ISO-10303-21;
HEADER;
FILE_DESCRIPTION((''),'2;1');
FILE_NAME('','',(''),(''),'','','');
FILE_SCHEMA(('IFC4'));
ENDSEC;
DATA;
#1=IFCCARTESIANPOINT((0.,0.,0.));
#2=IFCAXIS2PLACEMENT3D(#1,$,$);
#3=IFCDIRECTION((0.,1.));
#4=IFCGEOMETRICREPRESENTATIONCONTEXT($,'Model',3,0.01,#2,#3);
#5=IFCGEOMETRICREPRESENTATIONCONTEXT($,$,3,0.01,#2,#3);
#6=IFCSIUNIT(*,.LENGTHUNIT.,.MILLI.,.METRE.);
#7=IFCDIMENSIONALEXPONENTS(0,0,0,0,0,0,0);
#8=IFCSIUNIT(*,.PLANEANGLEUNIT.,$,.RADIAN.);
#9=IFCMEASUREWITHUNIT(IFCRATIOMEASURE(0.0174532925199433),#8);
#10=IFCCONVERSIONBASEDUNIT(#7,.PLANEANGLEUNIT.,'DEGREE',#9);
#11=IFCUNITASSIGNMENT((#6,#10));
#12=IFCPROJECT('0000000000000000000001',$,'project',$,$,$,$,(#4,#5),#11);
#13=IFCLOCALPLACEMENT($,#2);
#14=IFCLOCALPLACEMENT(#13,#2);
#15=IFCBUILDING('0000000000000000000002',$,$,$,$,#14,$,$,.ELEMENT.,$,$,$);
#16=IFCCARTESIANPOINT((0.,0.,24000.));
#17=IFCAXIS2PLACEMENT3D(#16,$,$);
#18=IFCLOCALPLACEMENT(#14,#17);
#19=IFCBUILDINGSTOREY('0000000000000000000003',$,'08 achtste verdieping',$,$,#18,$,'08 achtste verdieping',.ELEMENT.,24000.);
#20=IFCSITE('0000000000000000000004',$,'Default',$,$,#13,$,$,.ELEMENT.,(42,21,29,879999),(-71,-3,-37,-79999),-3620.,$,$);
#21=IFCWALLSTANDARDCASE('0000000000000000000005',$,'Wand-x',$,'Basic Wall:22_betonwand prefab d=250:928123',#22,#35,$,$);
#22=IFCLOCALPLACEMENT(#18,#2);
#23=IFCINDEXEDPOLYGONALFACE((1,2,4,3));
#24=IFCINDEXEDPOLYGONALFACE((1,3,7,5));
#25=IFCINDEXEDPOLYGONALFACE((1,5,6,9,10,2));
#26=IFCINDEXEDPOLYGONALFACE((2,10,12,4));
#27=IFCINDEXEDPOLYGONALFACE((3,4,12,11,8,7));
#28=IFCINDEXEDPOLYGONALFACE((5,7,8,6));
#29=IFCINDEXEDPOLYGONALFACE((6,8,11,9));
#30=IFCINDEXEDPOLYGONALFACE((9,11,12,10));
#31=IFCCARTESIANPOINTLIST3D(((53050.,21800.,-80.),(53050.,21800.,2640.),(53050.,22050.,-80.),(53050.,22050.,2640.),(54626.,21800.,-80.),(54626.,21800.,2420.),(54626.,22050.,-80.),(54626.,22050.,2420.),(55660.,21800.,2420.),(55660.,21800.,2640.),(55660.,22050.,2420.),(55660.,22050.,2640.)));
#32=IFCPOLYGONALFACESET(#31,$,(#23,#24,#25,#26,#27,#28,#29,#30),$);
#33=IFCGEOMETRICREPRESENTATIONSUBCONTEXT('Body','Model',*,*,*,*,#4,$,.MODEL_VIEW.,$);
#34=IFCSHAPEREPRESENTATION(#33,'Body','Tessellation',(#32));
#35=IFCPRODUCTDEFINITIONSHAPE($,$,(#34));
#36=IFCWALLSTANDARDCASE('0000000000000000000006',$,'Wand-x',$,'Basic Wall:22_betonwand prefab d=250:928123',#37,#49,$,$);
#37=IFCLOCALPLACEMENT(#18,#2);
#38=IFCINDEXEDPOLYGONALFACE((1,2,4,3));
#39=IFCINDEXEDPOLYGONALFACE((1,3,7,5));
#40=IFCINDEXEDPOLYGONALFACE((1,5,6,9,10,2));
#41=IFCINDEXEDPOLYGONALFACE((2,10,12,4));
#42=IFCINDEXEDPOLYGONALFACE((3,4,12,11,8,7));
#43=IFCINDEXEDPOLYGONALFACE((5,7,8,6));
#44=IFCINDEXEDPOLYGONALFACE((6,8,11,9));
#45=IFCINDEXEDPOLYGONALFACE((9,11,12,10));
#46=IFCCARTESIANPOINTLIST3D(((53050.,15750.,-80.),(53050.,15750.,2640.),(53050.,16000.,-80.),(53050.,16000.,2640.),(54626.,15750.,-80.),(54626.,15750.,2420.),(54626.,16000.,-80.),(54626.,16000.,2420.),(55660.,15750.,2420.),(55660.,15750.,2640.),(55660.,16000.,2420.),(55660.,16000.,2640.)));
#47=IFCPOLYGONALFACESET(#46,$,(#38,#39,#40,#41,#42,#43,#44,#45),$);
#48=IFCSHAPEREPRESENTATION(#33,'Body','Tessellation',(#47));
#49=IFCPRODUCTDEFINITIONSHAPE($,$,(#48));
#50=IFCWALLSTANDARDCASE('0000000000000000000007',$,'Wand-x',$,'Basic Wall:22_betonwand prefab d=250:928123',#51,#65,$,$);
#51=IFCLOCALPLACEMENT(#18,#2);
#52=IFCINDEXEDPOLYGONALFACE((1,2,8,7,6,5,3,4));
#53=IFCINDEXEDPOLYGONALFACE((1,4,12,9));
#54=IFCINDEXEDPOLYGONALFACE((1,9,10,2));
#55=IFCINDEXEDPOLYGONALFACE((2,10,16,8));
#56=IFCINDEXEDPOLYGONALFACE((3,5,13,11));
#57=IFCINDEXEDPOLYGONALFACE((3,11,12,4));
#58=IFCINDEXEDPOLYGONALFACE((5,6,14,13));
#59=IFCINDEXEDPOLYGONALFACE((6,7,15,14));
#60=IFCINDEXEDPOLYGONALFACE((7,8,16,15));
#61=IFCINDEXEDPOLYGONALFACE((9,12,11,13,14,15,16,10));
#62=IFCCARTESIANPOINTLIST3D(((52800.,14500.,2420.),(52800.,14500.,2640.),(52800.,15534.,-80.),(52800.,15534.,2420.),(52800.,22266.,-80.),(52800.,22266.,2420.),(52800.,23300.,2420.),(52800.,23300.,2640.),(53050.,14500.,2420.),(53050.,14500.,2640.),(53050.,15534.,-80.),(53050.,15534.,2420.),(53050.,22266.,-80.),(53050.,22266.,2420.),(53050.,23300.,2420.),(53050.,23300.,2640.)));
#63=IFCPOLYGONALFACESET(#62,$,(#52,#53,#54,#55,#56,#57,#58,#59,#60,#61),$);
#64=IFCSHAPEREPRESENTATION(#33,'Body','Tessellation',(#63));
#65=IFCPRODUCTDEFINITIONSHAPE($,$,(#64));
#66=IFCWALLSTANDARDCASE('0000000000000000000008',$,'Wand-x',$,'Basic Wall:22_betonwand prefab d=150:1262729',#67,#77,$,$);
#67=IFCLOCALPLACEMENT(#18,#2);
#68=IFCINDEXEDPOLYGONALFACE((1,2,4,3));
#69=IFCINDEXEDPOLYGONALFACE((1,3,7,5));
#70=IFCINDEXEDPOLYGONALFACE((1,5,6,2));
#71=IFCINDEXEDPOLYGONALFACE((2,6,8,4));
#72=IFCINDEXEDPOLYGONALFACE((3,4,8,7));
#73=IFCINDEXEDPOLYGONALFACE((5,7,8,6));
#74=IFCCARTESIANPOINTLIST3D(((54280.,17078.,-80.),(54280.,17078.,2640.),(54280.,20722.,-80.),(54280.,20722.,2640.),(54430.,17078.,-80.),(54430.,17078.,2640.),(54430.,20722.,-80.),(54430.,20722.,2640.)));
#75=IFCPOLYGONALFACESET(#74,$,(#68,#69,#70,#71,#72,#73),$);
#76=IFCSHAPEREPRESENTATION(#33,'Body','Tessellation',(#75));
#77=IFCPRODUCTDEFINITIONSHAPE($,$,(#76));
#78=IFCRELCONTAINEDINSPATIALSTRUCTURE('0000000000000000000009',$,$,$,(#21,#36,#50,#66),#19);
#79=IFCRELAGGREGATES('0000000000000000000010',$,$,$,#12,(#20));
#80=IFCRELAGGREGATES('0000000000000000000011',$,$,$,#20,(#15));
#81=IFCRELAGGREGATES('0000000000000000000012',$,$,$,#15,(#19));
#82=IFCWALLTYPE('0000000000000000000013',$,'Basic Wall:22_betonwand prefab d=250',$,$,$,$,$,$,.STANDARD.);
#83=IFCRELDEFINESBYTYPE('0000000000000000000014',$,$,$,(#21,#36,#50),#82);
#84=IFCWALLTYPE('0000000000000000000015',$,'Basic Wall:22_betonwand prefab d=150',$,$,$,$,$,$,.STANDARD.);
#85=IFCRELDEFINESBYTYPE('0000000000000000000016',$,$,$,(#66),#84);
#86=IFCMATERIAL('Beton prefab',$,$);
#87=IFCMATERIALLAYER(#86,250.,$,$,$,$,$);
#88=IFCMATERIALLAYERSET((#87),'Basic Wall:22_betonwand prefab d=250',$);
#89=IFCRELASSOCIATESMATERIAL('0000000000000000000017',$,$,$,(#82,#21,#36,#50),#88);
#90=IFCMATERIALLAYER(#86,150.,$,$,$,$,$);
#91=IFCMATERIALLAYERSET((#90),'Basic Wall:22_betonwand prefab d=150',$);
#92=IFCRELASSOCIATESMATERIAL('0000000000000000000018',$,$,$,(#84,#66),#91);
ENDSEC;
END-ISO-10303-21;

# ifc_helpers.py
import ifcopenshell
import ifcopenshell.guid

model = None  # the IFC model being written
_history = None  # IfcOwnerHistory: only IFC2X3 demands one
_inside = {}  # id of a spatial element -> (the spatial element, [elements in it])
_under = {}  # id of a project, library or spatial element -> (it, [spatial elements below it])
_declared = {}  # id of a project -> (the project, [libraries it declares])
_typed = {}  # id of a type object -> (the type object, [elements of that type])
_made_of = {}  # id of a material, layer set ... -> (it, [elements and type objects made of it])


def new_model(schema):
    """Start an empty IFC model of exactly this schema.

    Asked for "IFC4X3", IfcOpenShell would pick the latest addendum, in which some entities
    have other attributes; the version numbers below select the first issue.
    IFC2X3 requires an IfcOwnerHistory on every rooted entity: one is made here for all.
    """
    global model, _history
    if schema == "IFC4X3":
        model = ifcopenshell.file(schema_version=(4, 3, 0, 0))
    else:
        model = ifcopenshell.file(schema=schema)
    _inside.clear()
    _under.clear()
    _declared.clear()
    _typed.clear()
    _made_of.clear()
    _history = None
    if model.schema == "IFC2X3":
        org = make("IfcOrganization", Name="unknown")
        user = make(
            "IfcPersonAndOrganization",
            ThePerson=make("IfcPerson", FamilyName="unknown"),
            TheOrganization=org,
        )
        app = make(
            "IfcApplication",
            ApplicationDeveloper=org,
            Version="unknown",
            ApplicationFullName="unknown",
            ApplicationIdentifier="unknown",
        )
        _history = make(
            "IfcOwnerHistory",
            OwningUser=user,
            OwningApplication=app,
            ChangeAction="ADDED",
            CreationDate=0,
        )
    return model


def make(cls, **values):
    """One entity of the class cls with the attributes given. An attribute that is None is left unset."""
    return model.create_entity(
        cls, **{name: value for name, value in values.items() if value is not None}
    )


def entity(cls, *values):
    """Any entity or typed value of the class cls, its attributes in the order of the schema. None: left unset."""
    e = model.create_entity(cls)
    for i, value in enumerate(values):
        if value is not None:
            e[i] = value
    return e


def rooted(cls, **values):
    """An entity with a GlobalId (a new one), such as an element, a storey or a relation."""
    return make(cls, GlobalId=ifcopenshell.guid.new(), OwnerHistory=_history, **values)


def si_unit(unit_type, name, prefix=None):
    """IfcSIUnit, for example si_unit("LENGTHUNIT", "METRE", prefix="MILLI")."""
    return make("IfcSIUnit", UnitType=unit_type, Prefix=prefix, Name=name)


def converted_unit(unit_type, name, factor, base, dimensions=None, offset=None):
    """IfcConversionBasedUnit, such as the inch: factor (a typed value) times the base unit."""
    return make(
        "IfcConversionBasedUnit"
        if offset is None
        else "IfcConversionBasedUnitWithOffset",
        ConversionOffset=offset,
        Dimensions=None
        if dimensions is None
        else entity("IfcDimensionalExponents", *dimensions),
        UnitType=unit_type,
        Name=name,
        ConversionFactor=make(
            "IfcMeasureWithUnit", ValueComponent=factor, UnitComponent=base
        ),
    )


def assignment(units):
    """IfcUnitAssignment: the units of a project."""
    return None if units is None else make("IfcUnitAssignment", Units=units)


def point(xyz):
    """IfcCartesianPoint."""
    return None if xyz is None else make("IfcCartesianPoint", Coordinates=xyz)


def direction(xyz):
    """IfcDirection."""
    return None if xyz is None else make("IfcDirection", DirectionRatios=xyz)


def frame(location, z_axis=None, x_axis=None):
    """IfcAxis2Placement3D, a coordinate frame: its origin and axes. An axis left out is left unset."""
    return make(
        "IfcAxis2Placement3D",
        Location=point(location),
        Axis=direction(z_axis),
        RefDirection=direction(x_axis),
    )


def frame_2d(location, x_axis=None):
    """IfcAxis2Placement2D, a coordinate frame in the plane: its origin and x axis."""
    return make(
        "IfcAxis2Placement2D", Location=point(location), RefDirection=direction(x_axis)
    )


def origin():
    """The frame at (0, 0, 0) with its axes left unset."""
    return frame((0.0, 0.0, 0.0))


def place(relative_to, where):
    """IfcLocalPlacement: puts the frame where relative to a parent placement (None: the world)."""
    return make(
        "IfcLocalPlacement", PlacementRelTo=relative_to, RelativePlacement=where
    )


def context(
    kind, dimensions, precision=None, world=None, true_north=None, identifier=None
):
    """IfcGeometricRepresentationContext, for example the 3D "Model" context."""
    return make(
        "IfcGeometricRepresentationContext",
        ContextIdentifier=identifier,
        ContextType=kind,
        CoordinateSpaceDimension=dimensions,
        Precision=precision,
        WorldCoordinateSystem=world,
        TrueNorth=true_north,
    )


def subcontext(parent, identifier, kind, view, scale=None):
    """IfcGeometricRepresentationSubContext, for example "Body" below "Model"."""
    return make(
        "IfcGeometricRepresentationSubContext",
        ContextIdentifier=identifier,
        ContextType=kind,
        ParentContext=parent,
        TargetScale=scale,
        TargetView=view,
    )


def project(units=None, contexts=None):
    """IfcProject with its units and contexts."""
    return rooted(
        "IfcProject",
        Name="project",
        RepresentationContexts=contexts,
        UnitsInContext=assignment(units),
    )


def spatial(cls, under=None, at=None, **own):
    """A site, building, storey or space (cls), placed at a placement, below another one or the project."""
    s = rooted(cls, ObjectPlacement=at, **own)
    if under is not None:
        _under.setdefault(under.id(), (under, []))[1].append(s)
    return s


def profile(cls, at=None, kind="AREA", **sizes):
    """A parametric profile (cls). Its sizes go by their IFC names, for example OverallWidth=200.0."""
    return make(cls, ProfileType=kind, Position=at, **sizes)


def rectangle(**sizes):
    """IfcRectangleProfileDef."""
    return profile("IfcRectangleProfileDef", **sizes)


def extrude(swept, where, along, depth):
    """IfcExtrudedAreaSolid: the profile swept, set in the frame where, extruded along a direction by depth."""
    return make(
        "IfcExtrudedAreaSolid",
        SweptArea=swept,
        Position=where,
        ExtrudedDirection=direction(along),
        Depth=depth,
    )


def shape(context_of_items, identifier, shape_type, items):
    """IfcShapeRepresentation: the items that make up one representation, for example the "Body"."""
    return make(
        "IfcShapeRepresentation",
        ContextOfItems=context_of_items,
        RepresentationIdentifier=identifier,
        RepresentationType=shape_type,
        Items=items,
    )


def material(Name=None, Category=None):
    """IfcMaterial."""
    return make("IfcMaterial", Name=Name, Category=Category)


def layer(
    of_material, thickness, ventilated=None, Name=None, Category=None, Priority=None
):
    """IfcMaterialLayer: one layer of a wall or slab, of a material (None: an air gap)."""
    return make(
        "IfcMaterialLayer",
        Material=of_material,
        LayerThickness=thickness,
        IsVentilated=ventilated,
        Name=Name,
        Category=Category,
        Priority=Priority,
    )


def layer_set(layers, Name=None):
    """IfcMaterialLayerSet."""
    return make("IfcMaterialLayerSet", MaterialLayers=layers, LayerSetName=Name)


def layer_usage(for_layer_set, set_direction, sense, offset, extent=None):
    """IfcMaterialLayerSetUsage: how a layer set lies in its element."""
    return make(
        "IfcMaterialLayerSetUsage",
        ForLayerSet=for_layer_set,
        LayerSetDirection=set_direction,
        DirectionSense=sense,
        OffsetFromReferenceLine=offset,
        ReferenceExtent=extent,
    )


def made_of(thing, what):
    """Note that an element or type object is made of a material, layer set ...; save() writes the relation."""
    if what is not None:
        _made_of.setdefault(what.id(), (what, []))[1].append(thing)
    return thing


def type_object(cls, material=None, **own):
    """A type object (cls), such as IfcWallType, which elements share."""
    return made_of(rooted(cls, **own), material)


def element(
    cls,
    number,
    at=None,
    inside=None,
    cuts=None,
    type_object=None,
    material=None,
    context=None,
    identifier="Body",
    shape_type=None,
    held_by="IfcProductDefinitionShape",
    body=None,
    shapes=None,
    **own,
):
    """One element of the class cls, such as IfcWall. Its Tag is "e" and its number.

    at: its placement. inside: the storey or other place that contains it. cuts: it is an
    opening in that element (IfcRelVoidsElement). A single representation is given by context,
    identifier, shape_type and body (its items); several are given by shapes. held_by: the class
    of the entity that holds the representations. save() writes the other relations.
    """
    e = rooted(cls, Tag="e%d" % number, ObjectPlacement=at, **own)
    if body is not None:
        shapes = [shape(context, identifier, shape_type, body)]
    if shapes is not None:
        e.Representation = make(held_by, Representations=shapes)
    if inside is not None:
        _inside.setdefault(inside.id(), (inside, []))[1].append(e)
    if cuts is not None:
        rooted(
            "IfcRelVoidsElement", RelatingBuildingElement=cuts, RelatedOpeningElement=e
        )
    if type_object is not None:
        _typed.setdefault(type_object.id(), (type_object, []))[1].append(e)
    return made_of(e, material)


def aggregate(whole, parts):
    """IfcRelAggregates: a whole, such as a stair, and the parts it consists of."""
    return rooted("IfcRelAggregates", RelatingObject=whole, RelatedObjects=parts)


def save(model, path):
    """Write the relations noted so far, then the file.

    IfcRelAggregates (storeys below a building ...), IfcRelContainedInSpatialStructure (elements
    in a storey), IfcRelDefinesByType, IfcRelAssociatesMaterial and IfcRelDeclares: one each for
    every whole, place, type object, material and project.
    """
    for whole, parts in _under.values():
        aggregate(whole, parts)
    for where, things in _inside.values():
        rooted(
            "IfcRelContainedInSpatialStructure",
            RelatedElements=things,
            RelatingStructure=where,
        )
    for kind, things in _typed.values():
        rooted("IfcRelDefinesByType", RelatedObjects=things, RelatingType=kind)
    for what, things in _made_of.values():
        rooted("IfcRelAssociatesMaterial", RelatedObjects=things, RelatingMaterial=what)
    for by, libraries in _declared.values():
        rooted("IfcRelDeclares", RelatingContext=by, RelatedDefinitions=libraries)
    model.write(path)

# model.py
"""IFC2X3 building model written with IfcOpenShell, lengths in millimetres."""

from ifc_helpers import new_model, entity, si_unit, converted_unit, direction, frame, frame_2d, origin, place, context, subcontext, project, spatial, rectangle, extrude, material, layer, layer_set, layer_usage, type_object, element, save


model = new_model("IFC2X3")

# Units and contexts
model_context = context("Model", 3, precision=0.01, world=origin(), true_north=direction((0.0, 1.0)))
context_of_model = context(None, 3, precision=0.01, world=origin(), true_north=direction((0.0, 1.0)))
body_context = subcontext(model_context, "Body", "Model", "MODEL_VIEW")
ifc_project = project(units=[si_unit("LENGTHUNIT", "METRE", prefix="MILLI"), converted_unit("PLANEANGLEUNIT", "DEGREE", entity("IfcRatioMeasure", 0.0174532925199433), si_unit("PLANEANGLEUNIT", "RADIAN"), dimensions=[0, 0, 0, 0, 0, 0, 0])], contexts=[model_context, context_of_model])

# Site, building, storey
site_placement = place(None, origin())
site = spatial("IfcSite", under=ifc_project, at=site_placement, Name="Default", CompositionType="ELEMENT", RefLatitude=(42, 21, 29, 879999), RefLongitude=(-71, -3, -37, -79999), RefElevation=-3620.0)
building_placement = place(site_placement, origin())
building = spatial("IfcBuilding", under=site, at=building_placement, CompositionType="ELEMENT")
storey_placement = place(building_placement, frame((0.0, 0.0, 24000.0)))
storey = spatial("IfcBuildingStorey", under=building, at=storey_placement, Name="08 achtste verdieping", LongName="08 achtste verdieping", CompositionType="ELEMENT", Elevation=24000.0)

# Shared definitions
ifc_material_1 = material(Name="Beton prefab")

# Walls, openings
ifc_layer_1 = layer(ifc_material_1, 250.0)
ifc_layer_set_1 = layer_set([ifc_layer_1], Name="Basic Wall:22_betonwand prefab d=250")
ifc_layer_usage_1 = layer_usage(ifc_layer_set_1, "AXIS2", "NEGATIVE", 125.0)
wall_type_1 = type_object("IfcWallType", Name="Basic Wall:22_betonwand prefab d=250", PredefinedType="STANDARD", material=ifc_layer_set_1)
wall_1_placement = place(storey_placement, frame((53050.0, 21925.0, -80.0)))
wall_1 = element("IfcWallStandardCase", 1, at=wall_1_placement, inside=storey, type_object=wall_type_1, material=ifc_layer_usage_1, Name="Wand-x", ObjectType="Basic Wall:22_betonwand prefab d=250:928123", context=body_context, shape_type="SweptSolid", body=[
    extrude(rectangle(XDim=2610.0, YDim=250.0, at=frame_2d((1305.0, 0.0), x_axis=(-1.0, 0.0))), origin(), (0.0, 0.0, 1.0), 2720.0),
])
opening_1_placement = place(wall_1_placement, frame((-53050.0, -21925.0, 80.0)))
element("IfcOpeningElement", 2, at=opening_1_placement, cuts=wall_1, ObjectType="Opening", context=body_context, shape_type="SweptSolid", body=[
    extrude(rectangle(XDim=2500.0, YDim=1034.0, at=frame_2d((0.0, 0.0), x_axis=(1.0, 0.0))), frame((55143.0, 21525.0, 1170.0), z_axis=(0.0, 1.0, 0.0), x_axis=(0.0, 0.0, -1.0)), (0.0, 0.0, 1.0), 800.0),
])
ifc_layer_usage_2 = layer_usage(ifc_layer_set_1, "AXIS2", "POSITIVE", -125.0)
wall_2_placement = place(storey_placement, frame((53050.0, 15875.0, -80.0)))
wall_2 = element("IfcWallStandardCase", 3, at=wall_2_placement, inside=storey, type_object=wall_type_1, material=ifc_layer_usage_2, Name="Wand-x", ObjectType="Basic Wall:22_betonwand prefab d=250:928123", context=body_context, shape_type="SweptSolid", body=[
    extrude(rectangle(XDim=2610.0, YDim=250.0, at=frame_2d((1305.0, 0.0), x_axis=(-1.0, 0.0))), origin(), (0.0, 0.0, 1.0), 2720.0),
])
opening_2_placement = place(wall_2_placement, frame((-53050.0, -15875.0, 80.0)))
element("IfcOpeningElement", 4, at=opening_2_placement, cuts=wall_2, ObjectType="Opening", context=body_context, shape_type="SweptSolid", body=[
    extrude(rectangle(XDim=2500.0, YDim=1034.0, at=frame_2d((0.0, 0.0), x_axis=(1.0, 0.0))), frame((55143.0, 15475.0, 1170.0), z_axis=(0.0, 1.0, 0.0), x_axis=(0.0, 0.0, -1.0)), (0.0, 0.0, 1.0), 800.0),
])

# Wall, openings
ifc_layer_usage_3 = layer_usage(ifc_layer_set_1, "AXIS2", "NEGATIVE", 125.0)
wall_3_placement = place(storey_placement, frame((52925.0, 14500.0, -80.0), z_axis=(0.0, 0.0, 1.0), x_axis=(0.0, 1.0, 0.0)))
wall_3 = element("IfcWallStandardCase", 5, at=wall_3_placement, inside=storey, type_object=wall_type_1, material=ifc_layer_usage_3, Name="Wand-x", ObjectType="Basic Wall:22_betonwand prefab d=250:928123", context=body_context, shape_type="SweptSolid", body=[
    extrude(rectangle(XDim=8800.0, YDim=250.0, at=frame_2d((4400.0, 0.0), x_axis=(-1.0, 0.0))), origin(), (0.0, 0.0, 1.0), 2720.0),
])
opening_3_placement = place(wall_3_placement, frame((-14500.0, 52925.0, 80.0), z_axis=(0.0, 0.0, 1.0), x_axis=(0.0, -1.0, 0.0)))
element("IfcOpeningElement", 6, at=opening_3_placement, cuts=wall_3, ObjectType="Opening", context=body_context, shape_type="SweptSolid", body=[
    extrude(rectangle(XDim=2500.0, YDim=1034.0, at=frame_2d((0.0, 0.0), x_axis=(1.0, 0.0))), frame((53325.0, 15017.0, 1170.0), z_axis=(-1.0, 0.0, 0.0), x_axis=(0.0, 0.0, -1.0)), (0.0, 0.0, 1.0), 800.0),
])
opening_4_placement = place(wall_3_placement, frame((-14500.0, 52925.0, 80.0), z_axis=(0.0, 0.0, 1.0), x_axis=(0.0, -1.0, 0.0)))
element("IfcOpeningElement", 7, at=opening_4_placement, cuts=wall_3, ObjectType="Opening", context=body_context, shape_type="SweptSolid", body=[
    extrude(rectangle(XDim=2500.0, YDim=1034.0, at=frame_2d((0.0, 0.0), x_axis=(0.0, 1.0))), frame((53325.0, 22783.0, 1170.0), z_axis=(-1.0, 0.0, 0.0), x_axis=(0.0, 1.0, 0.0)), (0.0, 0.0, 1.0), 800.0),
])

# Wall
ifc_layer_2 = layer(ifc_material_1, 150.0)
ifc_layer_set_2 = layer_set([ifc_layer_2], Name="Basic Wall:22_betonwand prefab d=150")
ifc_layer_usage_4 = layer_usage(ifc_layer_set_2, "AXIS2", "NEGATIVE", 75.0)
wall_type_2 = type_object("IfcWallType", Name="Basic Wall:22_betonwand prefab d=150", PredefinedType="STANDARD", material=ifc_layer_set_2)
wall_4_placement = place(storey_placement, frame((54355.0, 17078.0, -80.0), z_axis=(0.0, 0.0, 1.0), x_axis=(0.0, 1.0, 0.0)))
element("IfcWallStandardCase", 8, at=wall_4_placement, inside=storey, type_object=wall_type_2, material=ifc_layer_usage_4, Name="Wand-x", ObjectType="Basic Wall:22_betonwand prefab d=150:1262729", context=body_context, shape_type="SweptSolid", body=[
    extrude(rectangle(XDim=3644.0, YDim=150.0, at=frame_2d((1822.0, 0.0), x_axis=(-1.0, 0.0))), origin(), (0.0, 0.0, 1.0), 2720.0),
])

save(model, "model.ifc")
